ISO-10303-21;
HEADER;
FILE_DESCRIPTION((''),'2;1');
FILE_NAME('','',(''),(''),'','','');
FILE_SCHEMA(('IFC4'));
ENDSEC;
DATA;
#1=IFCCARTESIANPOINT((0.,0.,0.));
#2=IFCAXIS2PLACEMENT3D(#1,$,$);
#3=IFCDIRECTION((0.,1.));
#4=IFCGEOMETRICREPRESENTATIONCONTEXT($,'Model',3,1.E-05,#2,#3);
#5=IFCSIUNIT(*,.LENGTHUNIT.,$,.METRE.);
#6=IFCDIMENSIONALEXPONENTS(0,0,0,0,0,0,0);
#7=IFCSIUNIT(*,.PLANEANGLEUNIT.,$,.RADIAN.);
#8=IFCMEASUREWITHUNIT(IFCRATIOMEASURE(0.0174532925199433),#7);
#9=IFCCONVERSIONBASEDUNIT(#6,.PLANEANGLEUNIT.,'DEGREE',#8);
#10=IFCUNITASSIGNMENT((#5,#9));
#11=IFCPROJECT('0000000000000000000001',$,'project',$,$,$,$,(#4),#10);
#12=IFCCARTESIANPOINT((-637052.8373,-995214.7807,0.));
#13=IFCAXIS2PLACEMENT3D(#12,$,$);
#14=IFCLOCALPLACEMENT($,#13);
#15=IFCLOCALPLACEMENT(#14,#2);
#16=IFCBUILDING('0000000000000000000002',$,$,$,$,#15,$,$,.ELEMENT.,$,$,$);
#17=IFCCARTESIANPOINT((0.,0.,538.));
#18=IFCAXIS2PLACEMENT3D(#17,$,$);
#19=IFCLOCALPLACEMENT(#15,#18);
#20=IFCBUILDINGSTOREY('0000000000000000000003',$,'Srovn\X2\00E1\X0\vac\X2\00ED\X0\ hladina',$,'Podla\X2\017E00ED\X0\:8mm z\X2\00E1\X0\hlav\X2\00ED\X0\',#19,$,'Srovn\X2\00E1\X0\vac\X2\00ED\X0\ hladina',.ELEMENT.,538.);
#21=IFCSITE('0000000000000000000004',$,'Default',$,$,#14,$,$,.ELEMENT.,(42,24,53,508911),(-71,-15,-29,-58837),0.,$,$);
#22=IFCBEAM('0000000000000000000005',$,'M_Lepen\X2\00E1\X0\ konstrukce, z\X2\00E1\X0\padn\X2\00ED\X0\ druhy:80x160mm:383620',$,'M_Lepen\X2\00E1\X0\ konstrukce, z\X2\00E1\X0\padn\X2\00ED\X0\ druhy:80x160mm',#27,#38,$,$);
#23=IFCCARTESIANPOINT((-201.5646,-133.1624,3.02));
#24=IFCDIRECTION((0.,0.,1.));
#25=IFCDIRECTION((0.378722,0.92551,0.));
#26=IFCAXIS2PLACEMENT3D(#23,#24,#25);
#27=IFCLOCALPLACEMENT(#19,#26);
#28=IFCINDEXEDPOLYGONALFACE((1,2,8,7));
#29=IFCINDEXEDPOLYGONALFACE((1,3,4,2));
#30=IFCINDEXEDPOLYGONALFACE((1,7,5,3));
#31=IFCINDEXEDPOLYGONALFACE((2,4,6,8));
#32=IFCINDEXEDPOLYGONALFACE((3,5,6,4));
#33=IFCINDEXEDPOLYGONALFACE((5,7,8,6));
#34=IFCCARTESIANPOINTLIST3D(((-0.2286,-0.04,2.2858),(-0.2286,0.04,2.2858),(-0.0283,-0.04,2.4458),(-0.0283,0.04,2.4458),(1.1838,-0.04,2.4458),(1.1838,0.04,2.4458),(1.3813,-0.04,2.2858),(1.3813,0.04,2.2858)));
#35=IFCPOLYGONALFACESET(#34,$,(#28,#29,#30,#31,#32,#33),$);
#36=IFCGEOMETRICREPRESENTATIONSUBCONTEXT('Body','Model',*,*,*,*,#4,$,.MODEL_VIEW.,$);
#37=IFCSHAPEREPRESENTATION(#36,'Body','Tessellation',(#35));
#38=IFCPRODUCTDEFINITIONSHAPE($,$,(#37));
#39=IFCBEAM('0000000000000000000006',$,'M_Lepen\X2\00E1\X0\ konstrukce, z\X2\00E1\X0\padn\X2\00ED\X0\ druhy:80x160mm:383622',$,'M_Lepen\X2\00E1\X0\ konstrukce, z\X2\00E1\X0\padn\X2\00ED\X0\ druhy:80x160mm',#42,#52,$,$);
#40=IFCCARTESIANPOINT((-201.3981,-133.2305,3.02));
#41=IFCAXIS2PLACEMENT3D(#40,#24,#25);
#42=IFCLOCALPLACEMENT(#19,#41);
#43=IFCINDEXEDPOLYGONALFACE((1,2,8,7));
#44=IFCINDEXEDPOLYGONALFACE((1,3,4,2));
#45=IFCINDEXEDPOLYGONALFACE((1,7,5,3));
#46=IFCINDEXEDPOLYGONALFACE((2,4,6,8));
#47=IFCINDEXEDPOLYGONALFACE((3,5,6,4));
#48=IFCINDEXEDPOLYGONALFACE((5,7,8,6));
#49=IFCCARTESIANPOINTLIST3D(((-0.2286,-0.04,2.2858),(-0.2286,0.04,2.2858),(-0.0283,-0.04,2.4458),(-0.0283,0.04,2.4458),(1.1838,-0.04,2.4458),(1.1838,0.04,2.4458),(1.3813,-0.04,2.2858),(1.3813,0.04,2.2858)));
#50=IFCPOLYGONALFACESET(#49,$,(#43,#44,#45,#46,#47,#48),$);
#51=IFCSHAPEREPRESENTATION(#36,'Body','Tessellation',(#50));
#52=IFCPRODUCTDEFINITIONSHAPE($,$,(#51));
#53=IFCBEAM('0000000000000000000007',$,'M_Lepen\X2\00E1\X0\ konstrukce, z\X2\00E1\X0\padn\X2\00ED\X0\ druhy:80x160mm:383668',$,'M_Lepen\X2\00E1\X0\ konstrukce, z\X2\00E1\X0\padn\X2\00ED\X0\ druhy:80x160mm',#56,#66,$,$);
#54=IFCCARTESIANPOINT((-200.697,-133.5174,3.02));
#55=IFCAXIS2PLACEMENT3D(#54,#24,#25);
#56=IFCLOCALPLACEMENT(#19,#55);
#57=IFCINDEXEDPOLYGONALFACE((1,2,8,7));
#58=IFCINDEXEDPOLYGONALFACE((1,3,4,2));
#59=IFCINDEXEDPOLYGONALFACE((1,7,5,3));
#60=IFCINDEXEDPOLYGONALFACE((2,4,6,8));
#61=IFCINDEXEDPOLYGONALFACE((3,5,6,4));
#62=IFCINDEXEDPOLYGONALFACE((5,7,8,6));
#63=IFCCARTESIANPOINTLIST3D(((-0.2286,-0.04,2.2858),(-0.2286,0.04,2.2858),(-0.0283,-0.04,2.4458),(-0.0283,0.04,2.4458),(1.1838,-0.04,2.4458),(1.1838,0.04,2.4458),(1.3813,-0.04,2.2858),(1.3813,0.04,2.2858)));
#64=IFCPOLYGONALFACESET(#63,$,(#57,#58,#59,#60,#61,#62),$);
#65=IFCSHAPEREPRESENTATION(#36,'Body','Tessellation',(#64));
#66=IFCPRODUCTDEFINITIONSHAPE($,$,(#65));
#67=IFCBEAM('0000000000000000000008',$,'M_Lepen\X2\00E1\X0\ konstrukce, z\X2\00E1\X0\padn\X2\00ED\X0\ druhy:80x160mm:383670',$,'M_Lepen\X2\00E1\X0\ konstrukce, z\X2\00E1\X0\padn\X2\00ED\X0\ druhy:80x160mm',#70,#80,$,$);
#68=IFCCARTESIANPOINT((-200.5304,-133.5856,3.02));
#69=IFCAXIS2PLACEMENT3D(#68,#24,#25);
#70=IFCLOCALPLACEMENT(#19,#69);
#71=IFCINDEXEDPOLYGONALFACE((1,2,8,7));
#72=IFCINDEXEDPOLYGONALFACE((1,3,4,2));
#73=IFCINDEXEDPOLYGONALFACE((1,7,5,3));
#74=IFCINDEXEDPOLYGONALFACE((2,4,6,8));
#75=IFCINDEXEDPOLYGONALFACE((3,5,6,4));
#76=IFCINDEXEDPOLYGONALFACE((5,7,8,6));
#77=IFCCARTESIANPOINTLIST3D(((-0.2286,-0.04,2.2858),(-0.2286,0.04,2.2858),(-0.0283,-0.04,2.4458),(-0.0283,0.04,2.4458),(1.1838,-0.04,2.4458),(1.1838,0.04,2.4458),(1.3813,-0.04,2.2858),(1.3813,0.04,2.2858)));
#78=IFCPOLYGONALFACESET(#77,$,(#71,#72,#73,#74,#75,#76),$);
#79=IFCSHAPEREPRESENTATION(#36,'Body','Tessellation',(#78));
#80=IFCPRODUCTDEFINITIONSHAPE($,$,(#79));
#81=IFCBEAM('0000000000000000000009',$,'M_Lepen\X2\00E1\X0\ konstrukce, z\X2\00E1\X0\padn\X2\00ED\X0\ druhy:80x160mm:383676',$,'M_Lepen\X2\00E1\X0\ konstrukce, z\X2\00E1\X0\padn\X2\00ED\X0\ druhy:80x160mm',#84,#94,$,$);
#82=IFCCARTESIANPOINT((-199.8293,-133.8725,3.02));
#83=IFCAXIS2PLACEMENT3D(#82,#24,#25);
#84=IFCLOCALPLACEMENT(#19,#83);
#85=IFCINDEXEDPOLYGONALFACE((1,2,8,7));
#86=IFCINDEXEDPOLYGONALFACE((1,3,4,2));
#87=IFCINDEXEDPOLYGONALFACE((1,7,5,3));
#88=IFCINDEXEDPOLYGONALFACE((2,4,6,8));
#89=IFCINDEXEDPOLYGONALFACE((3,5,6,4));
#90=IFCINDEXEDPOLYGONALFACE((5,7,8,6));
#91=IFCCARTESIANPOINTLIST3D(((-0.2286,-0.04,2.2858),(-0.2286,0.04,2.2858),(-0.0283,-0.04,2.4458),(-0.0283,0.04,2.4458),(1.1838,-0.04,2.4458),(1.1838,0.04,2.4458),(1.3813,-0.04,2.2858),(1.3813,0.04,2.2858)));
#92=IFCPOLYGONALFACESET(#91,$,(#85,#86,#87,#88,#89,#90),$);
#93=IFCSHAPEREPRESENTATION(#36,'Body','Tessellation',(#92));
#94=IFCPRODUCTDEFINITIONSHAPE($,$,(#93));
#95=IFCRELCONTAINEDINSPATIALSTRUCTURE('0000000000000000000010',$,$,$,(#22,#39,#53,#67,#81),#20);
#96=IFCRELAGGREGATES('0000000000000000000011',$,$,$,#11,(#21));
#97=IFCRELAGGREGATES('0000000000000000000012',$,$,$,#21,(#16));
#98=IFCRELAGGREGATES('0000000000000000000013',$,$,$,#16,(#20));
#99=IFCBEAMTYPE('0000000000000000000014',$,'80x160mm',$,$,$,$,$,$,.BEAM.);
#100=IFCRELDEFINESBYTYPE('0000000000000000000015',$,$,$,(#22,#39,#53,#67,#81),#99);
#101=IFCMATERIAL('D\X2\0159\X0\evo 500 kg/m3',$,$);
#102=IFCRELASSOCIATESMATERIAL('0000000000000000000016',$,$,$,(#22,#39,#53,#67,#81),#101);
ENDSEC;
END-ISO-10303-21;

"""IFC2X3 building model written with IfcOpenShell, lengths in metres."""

from ifc_helpers import new_model, entity, si_unit, converted_unit, direction, frame, frame_2d, origin, origin_2d_with_axis, place, context, subcontext, project, spatial, rectangle, extrude, clip, halfspace, material, type_object, element, save


model = new_model("IFC2X3")

# Units and contexts
model_context = context("Model", 3, precision=1e-05, world=origin(), true_north=direction((0.0, 1.0)))
body_context = subcontext(model_context, "Body", "Model", "MODEL_VIEW")
ifc_project = project(units=[si_unit("LENGTHUNIT", "METRE"), converted_unit("PLANEANGLEUNIT", "DEGREE", entity("IfcRatioMeasure", 0.0174532925199433), si_unit("PLANEANGLEUNIT", "RADIAN"), dimensions=[0, 0, 0, 0, 0, 0, 0])], contexts=[model_context])

# Site, building, storey
site_placement = place(None, frame((-637052.8373, -995214.7807, 0.0)))
site = spatial("IfcSite", under=ifc_project, at=site_placement, Name="Default", CompositionType="ELEMENT", RefLatitude=(42, 24, 53, 508911), RefLongitude=(-71, -15, -29, -58837), RefElevation=0.0)
building_placement = place(site_placement, origin())
building = spatial("IfcBuilding", under=site, at=building_placement, CompositionType="ELEMENT")
storey_placement = place(building_placement, frame((0.0, 0.0, 538.0)))
storey = spatial("IfcBuildingStorey", under=building, at=storey_placement, Name="Srovnávací hladina", ObjectType="Podlaží:8mm záhlaví", LongName="Srovnávací hladina", CompositionType="ELEMENT", Elevation=538.0)

# Beams
ifc_material_1 = material(Name="Dřevo 500 kg/m3")
beam_type_1 = type_object("IfcBeamType", Name="80x160mm", PredefinedType="BEAM")
beam_1_placement = place(storey_placement, frame((-201.5646, -133.1624, 3.02), z_axis=(0.0, 0.0, 1.0), x_axis=(0.378722, 0.92551, 0.0)))
element("IfcBeam", 1, at=beam_1_placement, inside=storey, type_object=beam_type_1, material=ifc_material_1, Name="M_Lepená konstrukce, západní druhy:80x160mm:383620", ObjectType="M_Lepená konstrukce, západní druhy:80x160mm", context=body_context, shape_type="Clipping", body=[
    clip(clip(extrude(rectangle(XDim=0.16, YDim=0.08, at=origin_2d_with_axis()), frame((-0.2286, 0.0, 2.3658), z_axis=(1.0, 0.0, 0.0), x_axis=(0.0, 0.0, -1.0)), (0.0, 0.0, 1.0), 1.6099), halfspace(frame((1.1838, -2.1025, 2.4458), z_axis=(0.629499, 0.0, 0.777001), x_axis=(-0.777001, 0.0, 0.629499)), False)), halfspace(frame((-0.0283, -2.1025, 2.4458), z_axis=(-0.624034, 0.0, 0.781397), x_axis=(0.781397, 0.0, 0.624034)), False)),
])
beam_2_placement = place(storey_placement, frame((-201.3981, -133.2305, 3.02), z_axis=(0.0, 0.0, 1.0), x_axis=(0.378722, 0.92551, 0.0)))
element("IfcBeam", 2, at=beam_2_placement, inside=storey, type_object=beam_type_1, material=ifc_material_1, Name="M_Lepená konstrukce, západní druhy:80x160mm:383622", ObjectType="M_Lepená konstrukce, západní druhy:80x160mm", context=body_context, shape_type="Clipping", body=[
    clip(clip(extrude(rectangle(XDim=0.16, YDim=0.08, at=origin_2d_with_axis()), frame((-0.2286, 0.0, 2.3658), z_axis=(1.0, 0.0, 0.0), x_axis=(0.0, 0.0, -1.0)), (0.0, 0.0, 1.0), 1.6099), halfspace(frame((1.1838, -1.9225, 2.4458), z_axis=(0.629499, 0.0, 0.777001), x_axis=(-0.777001, 0.0, 0.629499)), False)), halfspace(frame((-0.0283, -1.9225, 2.4458), z_axis=(-0.624034, 0.0, 0.781397), x_axis=(0.781397, 0.0, 0.624034)), False)),
])
beam_3_placement = place(storey_placement, frame((-200.697, -133.5174, 3.02), z_axis=(0.0, 0.0, 1.0), x_axis=(0.378722, 0.92551, 0.0)))
element("IfcBeam", 3, at=beam_3_placement, inside=storey, type_object=beam_type_1, material=ifc_material_1, Name="M_Lepená konstrukce, západní druhy:80x160mm:383668", ObjectType="M_Lepená konstrukce, západní druhy:80x160mm", context=body_context, shape_type="Clipping", body=[
    clip(clip(extrude(rectangle(XDim=0.16, YDim=0.08, at=origin_2d_with_axis()), frame((-0.2286, 0.0, 2.3658), z_axis=(1.0, 0.0, 0.0), x_axis=(0.0, 0.0, -1.0)), (0.0, 0.0, 1.0), 1.6099), halfspace(frame((1.1838, -1.165, 2.4458), z_axis=(0.629499, 0.0, 0.777001), x_axis=(-0.777001, 0.0, 0.629499)), False)), halfspace(frame((-0.0283, -1.165, 2.4458), z_axis=(-0.624034, 0.0, 0.781397), x_axis=(0.781397, 0.0, 0.624034)), False)),
])
beam_4_placement = place(storey_placement, frame((-200.5304, -133.5856, 3.02), z_axis=(0.0, 0.0, 1.0), x_axis=(0.378722, 0.92551, 0.0)))
element("IfcBeam", 4, at=beam_4_placement, inside=storey, type_object=beam_type_1, material=ifc_material_1, Name="M_Lepená konstrukce, západní druhy:80x160mm:383670", ObjectType="M_Lepená konstrukce, západní druhy:80x160mm", context=body_context, shape_type="Clipping", body=[
    clip(clip(extrude(rectangle(XDim=0.16, YDim=0.08, at=frame_2d((0.0, 0.0), x_axis=(1.0, 0.0))), frame((-0.2286, 0.0, 2.3658), z_axis=(1.0, 0.0, 0.0), x_axis=(0.0, 0.0, -1.0)), (0.0, 0.0, 1.0), 1.6099), halfspace(frame((1.1838, -0.985, 2.4458), z_axis=(0.629499, 0.0, 0.777001), x_axis=(-0.777001, 0.0, 0.629499)), False)), halfspace(frame((-0.0283, -0.985, 2.4458), z_axis=(-0.624034, 0.0, 0.781397), x_axis=(0.781397, 0.0, 0.624034)), False)),
])
beam_5_placement = place(storey_placement, frame((-199.8293, -133.8725, 3.02), z_axis=(0.0, 0.0, 1.0), x_axis=(0.378722, 0.92551, 0.0)))
element("IfcBeam", 5, at=beam_5_placement, inside=storey, type_object=beam_type_1, material=ifc_material_1, Name="M_Lepená konstrukce, západní druhy:80x160mm:383676", ObjectType="M_Lepená konstrukce, západní druhy:80x160mm", context=body_context, shape_type="Clipping", body=[
    clip(clip(extrude(rectangle(XDim=0.16, YDim=0.08, at=origin_2d_with_axis()), frame((-0.2286, 0.0, 2.3658), z_axis=(1.0, 0.0, 0.0), x_axis=(0.0, 0.0, -1.0)), (0.0, 0.0, 1.0), 1.6099), halfspace(frame((1.1838, -0.2275, 2.4458), z_axis=(0.629499, 0.0, 0.777001), x_axis=(-0.777001, 0.0, 0.629499)), False)), halfspace(frame((-0.0283, -0.2275, 2.4458), z_axis=(-0.624034, 0.0, 0.781397), x_axis=(0.781397, 0.0, 0.624034)), False)),
])

save(model, "model.ifc")
